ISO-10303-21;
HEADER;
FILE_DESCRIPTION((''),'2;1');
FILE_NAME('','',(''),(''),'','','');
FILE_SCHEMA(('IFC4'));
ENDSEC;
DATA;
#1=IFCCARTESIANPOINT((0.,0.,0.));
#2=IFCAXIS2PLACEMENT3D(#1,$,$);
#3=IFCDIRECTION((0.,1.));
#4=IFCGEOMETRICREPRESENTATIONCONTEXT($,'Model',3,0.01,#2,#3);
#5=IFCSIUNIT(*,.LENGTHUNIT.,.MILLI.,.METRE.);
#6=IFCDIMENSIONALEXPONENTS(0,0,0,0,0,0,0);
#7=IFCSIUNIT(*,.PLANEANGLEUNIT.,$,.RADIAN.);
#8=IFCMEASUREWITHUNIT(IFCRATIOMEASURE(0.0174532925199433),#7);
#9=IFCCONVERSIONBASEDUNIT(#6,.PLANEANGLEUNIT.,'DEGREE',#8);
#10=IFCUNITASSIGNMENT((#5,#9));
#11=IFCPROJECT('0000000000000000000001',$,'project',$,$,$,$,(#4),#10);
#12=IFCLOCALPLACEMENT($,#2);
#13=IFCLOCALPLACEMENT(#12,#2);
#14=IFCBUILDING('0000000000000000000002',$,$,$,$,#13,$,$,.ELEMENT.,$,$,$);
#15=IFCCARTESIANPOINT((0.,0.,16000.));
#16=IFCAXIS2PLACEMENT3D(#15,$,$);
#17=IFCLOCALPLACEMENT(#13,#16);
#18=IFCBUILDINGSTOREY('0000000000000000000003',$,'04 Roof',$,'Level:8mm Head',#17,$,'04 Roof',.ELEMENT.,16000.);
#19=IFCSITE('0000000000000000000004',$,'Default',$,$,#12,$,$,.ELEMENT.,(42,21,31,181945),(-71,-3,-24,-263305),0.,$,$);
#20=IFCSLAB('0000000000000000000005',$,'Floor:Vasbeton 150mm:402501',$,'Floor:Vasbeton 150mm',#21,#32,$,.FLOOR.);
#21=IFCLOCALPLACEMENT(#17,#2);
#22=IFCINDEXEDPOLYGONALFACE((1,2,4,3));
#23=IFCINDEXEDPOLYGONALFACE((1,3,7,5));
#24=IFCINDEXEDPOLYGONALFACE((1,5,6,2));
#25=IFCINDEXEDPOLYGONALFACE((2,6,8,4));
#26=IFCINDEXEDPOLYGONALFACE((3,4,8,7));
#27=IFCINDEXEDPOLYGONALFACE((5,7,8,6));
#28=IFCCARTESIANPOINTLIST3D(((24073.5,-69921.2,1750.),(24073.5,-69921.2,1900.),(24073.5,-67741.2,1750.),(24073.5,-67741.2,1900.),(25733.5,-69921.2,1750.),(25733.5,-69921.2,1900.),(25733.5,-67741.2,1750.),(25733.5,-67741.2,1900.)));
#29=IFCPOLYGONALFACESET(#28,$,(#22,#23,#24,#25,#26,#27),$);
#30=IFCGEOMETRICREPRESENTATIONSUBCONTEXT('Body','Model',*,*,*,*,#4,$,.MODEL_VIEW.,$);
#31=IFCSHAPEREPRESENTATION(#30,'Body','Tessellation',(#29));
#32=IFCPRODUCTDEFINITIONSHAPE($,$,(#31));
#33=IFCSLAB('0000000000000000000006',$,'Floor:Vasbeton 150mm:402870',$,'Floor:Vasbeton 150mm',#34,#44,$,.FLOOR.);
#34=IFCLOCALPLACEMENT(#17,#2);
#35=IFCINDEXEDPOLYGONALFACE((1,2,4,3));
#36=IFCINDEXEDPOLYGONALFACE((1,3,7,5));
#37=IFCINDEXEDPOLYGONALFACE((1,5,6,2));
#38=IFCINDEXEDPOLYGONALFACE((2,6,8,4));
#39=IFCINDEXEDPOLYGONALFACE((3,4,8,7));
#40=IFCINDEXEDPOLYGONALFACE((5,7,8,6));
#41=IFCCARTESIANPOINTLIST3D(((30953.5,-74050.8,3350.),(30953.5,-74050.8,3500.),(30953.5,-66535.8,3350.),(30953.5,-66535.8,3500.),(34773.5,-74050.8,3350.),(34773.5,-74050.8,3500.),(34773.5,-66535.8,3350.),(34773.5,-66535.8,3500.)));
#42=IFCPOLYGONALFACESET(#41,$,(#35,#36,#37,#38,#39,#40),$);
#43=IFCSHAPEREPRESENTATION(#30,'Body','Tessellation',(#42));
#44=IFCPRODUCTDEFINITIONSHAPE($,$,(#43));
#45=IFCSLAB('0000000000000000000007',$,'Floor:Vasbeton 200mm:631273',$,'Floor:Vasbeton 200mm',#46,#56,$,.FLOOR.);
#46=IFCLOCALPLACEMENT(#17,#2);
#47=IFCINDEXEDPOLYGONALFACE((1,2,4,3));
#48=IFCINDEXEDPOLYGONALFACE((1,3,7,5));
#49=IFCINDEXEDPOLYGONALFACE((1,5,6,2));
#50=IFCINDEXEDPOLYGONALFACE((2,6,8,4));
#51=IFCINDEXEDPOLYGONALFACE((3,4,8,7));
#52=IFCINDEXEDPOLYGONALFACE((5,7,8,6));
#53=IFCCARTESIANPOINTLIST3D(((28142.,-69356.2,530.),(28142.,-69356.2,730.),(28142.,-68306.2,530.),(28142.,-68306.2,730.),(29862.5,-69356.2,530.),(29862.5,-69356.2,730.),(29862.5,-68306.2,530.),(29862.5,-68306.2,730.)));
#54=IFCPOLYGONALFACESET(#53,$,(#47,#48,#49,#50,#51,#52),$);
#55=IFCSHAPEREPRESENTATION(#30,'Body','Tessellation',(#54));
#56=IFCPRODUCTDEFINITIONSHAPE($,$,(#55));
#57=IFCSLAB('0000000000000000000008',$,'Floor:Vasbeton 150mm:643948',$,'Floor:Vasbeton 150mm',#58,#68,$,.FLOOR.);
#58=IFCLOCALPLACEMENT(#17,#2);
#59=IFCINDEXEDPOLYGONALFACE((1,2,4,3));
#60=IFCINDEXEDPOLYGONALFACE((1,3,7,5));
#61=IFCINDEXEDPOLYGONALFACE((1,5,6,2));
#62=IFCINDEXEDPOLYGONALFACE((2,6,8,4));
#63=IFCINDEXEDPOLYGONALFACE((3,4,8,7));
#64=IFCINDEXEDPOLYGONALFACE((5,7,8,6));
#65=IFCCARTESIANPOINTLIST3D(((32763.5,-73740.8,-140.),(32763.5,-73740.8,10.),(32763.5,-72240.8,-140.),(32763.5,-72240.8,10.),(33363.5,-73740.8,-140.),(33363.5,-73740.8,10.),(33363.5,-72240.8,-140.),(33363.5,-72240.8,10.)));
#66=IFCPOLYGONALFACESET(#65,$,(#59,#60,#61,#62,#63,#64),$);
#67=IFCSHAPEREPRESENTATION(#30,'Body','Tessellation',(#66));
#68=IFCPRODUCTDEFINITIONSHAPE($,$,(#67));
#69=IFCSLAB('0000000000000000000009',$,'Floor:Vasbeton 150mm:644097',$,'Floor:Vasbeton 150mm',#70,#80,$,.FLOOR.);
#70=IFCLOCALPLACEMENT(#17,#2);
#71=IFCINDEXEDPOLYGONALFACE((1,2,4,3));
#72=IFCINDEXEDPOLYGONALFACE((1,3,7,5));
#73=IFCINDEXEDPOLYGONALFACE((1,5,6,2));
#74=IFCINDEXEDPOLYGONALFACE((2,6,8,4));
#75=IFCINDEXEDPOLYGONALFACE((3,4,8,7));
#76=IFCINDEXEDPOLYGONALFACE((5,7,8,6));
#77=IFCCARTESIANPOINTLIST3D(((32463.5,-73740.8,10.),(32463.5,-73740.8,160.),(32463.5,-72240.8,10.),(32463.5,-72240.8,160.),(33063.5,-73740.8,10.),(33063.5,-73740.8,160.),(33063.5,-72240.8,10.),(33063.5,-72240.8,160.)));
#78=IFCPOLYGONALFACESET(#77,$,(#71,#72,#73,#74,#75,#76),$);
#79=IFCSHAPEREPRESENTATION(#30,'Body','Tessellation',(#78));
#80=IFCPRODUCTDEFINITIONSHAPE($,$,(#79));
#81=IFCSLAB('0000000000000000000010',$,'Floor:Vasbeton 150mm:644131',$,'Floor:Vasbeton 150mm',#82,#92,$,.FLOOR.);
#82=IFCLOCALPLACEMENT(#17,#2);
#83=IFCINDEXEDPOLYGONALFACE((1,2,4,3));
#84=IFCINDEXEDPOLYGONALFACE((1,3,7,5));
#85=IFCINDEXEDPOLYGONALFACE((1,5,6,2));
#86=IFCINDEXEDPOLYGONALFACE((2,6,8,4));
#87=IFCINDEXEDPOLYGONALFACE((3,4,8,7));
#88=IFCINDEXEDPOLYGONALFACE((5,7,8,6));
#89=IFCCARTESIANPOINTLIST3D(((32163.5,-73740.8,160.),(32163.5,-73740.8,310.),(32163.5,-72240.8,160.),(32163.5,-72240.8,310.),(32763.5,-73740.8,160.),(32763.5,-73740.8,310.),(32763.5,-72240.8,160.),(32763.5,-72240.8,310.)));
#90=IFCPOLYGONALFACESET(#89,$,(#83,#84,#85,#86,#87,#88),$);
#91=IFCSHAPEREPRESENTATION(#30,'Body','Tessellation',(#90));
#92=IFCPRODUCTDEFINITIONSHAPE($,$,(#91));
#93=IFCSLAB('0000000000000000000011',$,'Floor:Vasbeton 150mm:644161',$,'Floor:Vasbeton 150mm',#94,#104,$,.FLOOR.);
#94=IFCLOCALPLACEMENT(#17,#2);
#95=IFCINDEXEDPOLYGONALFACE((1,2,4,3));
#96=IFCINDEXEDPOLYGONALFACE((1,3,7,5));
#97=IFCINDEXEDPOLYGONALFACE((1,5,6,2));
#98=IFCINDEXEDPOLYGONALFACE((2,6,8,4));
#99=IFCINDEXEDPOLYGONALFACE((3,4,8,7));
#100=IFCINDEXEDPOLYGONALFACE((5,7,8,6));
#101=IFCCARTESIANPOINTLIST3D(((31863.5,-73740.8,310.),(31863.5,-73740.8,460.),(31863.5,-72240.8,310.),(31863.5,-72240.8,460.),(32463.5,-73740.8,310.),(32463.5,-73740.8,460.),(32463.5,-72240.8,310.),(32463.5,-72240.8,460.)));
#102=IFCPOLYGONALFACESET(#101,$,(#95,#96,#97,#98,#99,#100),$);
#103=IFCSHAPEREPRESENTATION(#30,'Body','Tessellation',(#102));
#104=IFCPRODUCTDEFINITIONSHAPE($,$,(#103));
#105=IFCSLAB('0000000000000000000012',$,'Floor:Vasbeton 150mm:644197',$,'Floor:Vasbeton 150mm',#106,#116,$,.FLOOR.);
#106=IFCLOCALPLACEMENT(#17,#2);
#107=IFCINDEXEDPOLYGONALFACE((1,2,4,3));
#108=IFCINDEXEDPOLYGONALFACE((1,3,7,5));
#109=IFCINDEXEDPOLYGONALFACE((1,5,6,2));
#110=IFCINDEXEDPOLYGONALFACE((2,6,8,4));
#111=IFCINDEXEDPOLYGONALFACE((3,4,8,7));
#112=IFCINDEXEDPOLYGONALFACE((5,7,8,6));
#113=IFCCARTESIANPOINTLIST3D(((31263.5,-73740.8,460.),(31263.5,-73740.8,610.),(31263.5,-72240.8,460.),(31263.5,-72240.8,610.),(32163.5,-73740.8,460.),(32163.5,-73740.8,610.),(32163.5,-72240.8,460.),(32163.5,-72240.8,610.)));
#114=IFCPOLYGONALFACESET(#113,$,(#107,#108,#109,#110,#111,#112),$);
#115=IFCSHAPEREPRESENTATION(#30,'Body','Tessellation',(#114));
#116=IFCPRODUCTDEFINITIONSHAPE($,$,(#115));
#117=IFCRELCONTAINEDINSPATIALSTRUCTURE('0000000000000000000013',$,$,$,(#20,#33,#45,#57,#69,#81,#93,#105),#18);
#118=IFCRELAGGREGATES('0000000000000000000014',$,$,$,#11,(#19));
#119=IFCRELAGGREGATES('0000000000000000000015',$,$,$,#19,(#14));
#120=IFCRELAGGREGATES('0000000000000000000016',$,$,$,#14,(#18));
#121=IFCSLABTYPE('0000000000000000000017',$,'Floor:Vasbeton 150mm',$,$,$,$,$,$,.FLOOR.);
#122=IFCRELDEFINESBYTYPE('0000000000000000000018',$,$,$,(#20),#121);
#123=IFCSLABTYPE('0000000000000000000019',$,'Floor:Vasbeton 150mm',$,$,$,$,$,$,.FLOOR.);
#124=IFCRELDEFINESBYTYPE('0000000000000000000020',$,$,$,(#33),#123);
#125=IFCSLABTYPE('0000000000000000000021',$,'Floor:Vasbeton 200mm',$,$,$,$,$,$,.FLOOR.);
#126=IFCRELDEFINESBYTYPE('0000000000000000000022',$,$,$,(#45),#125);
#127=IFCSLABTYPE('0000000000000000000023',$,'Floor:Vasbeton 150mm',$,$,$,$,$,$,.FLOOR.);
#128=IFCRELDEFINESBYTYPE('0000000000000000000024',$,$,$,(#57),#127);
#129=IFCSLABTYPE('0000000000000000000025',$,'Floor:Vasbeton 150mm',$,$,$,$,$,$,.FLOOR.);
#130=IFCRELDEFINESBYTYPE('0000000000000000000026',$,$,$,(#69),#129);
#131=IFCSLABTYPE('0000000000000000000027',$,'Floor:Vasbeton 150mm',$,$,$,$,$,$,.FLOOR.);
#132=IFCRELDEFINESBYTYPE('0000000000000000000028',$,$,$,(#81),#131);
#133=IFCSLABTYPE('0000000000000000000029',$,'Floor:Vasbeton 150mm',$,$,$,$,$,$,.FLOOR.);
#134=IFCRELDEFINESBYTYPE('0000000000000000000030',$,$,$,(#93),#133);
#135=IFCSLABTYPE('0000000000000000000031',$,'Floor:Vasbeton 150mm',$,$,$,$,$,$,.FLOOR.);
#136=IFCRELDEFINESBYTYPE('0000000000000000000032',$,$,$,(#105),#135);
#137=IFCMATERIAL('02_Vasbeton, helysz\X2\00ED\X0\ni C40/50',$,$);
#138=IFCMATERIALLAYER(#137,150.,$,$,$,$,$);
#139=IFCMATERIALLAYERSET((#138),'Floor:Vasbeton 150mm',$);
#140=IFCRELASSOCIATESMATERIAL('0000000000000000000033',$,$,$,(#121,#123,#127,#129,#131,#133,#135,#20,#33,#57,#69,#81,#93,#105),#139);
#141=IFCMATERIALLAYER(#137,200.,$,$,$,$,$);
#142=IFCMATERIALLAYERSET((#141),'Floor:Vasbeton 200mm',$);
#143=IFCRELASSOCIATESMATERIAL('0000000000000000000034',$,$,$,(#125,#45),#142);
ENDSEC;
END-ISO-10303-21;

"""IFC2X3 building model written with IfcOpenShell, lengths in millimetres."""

from ifc_helpers import new_model, entity, si_unit, converted_unit, direction, frame, frame_2d, origin, origin_2d_with_axis, place, context, subcontext, project, spatial, rectangle, extrude, material, layer, layer_set, layer_usage, type_object, element, save


model = new_model("IFC2X3")

# Units and contexts
model_context = context("Model", 3, precision=0.01, world=origin(), true_north=direction((0.0, 1.0)))
body_context = subcontext(model_context, "Body", "Model", "MODEL_VIEW")
ifc_project = project(units=[si_unit("LENGTHUNIT", "METRE", prefix="MILLI"), converted_unit("PLANEANGLEUNIT", "DEGREE", entity("IfcRatioMeasure", 0.0174532925199433), si_unit("PLANEANGLEUNIT", "RADIAN"), dimensions=[0, 0, 0, 0, 0, 0, 0])], contexts=[model_context])

# Site, building, storey
site_placement = place(None, origin())
site = spatial("IfcSite", under=ifc_project, at=site_placement, Name="Default", CompositionType="ELEMENT", RefLatitude=(42, 21, 31, 181945), RefLongitude=(-71, -3, -24, -263305), RefElevation=0.0)
building_placement = place(site_placement, origin())
building = spatial("IfcBuilding", under=site, at=building_placement, CompositionType="ELEMENT")
storey_placement = place(building_placement, frame((0.0, 0.0, 16000.0)))
storey = spatial("IfcBuildingStorey", under=building, at=storey_placement, Name="04 Roof", ObjectType="Level:8mm Head", LongName="04 Roof", CompositionType="ELEMENT", Elevation=16000.0)

# Shared definitions
ifc_material = material(Name="02_Vasbeton, helyszíni C40/50")
ifc_layer_1 = layer(ifc_material, 200.0)
ifc_layer_set_1 = layer_set([ifc_layer_1], Name="Floor:Vasbeton 200mm")

# Slabs
ifc_layer_2 = layer(ifc_material, 150.0)
ifc_layer_set_2 = layer_set([ifc_layer_2], Name="Floor:Vasbeton 150mm")
ifc_layer_usage_1 = layer_usage(ifc_layer_set_2, "AXIS3", "POSITIVE", 0.0)
slab_type_1 = type_object("IfcSlabType", Name="Floor:Vasbeton 150mm", PredefinedType="FLOOR", material=ifc_layer_set_2)
slab_1_placement = place(storey_placement, origin())
element("IfcSlab", 1, at=slab_1_placement, inside=storey, type_object=slab_type_1, material=ifc_layer_usage_1, Name="Floor:Vasbeton 150mm:402501", ObjectType="Floor:Vasbeton 150mm", PredefinedType="FLOOR", context=body_context, shape_type="SweptSolid", body=[
    extrude(rectangle(XDim=2180.0, YDim=1660.0, at=frame_2d((0.0, 0.0), x_axis=(1.0, 0.0))), frame((24903.5, -68831.2, 1900.0), z_axis=(0.0, 0.0, -1.0), x_axis=(0.0, 1.0, 0.0)), (0.0, 0.0, 1.0), 150.0),
])
ifc_layer_usage_2 = layer_usage(ifc_layer_set_2, "AXIS3", "POSITIVE", 0.0)
slab_type_2 = type_object("IfcSlabType", Name="Floor:Vasbeton 150mm", PredefinedType="FLOOR", material=ifc_layer_set_2)
slab_2_placement = place(storey_placement, origin())
element("IfcSlab", 2, at=slab_2_placement, inside=storey, type_object=slab_type_2, material=ifc_layer_usage_2, Name="Floor:Vasbeton 150mm:402870", ObjectType="Floor:Vasbeton 150mm", PredefinedType="FLOOR", context=body_context, shape_type="SweptSolid", body=[
    extrude(rectangle(XDim=7515.0, YDim=3820.0, at=origin_2d_with_axis()), frame((32863.5, -70293.3, 3500.0), z_axis=(0.0, 0.0, -1.0), x_axis=(0.0, 1.0, 0.0)), (0.0, 0.0, 1.0), 150.0),
])
ifc_layer_usage_3 = layer_usage(ifc_layer_set_1, "AXIS3", "POSITIVE", 0.0)
slab_type_3 = type_object("IfcSlabType", Name="Floor:Vasbeton 200mm", PredefinedType="FLOOR", material=ifc_layer_set_1)
slab_3_placement = place(storey_placement, origin())
element("IfcSlab", 3, at=slab_3_placement, inside=storey, type_object=slab_type_3, material=ifc_layer_usage_3, Name="Floor:Vasbeton 200mm:631273", ObjectType="Floor:Vasbeton 200mm", PredefinedType="FLOOR", context=body_context, shape_type="SweptSolid", body=[
    extrude(rectangle(XDim=1050.0, YDim=1720.4, at=frame_2d((0.0, 0.0), x_axis=(1.0, 0.0))), frame((29002.2, -68831.2, 730.0), z_axis=(0.0, 0.0, -1.0), x_axis=(0.0, 1.0, 0.0)), (0.0, 0.0, 1.0), 200.0),
])
ifc_layer_usage_4 = layer_usage(ifc_layer_set_2, "AXIS3", "POSITIVE", 0.0)
slab_type_4 = type_object("IfcSlabType", Name="Floor:Vasbeton 150mm", PredefinedType="FLOOR", material=ifc_layer_set_2)
slab_4_placement = place(storey_placement, origin())
element("IfcSlab", 4, at=slab_4_placement, inside=storey, type_object=slab_type_4, material=ifc_layer_usage_4, Name="Floor:Vasbeton 150mm:643948", ObjectType="Floor:Vasbeton 150mm", PredefinedType="FLOOR", context=body_context, shape_type="SweptSolid", body=[
    extrude(rectangle(XDim=1500.0, YDim=600.0, at=frame_2d((0.0, 0.0), x_axis=(1.0, 0.0))), frame((33063.5, -72990.8, 10.0), z_axis=(0.0, 0.0, -1.0), x_axis=(0.0, 1.0, 0.0)), (0.0, 0.0, 1.0), 150.0),
])
ifc_layer_usage_5 = layer_usage(ifc_layer_set_2, "AXIS3", "POSITIVE", 0.0)
slab_type_5 = type_object("IfcSlabType", Name="Floor:Vasbeton 150mm", PredefinedType="FLOOR", material=ifc_layer_set_2)
slab_5_placement = place(storey_placement, origin())
element("IfcSlab", 5, at=slab_5_placement, inside=storey, type_object=slab_type_5, material=ifc_layer_usage_5, Name="Floor:Vasbeton 150mm:644097", ObjectType="Floor:Vasbeton 150mm", PredefinedType="FLOOR", context=body_context, shape_type="SweptSolid", body=[
    extrude(rectangle(XDim=1500.0, YDim=600.0, at=frame_2d((0.0, 0.0), x_axis=(1.0, 0.0))), frame((32763.5, -72990.8, 160.0), z_axis=(0.0, 0.0, -1.0), x_axis=(0.0, 1.0, 0.0)), (0.0, 0.0, 1.0), 150.0),
])
ifc_layer_usage_6 = layer_usage(ifc_layer_set_2, "AXIS3", "POSITIVE", 0.0)
slab_type_6 = type_object("IfcSlabType", Name="Floor:Vasbeton 150mm", PredefinedType="FLOOR", material=ifc_layer_set_2)
slab_6_placement = place(storey_placement, origin())
element("IfcSlab", 6, at=slab_6_placement, inside=storey, type_object=slab_type_6, material=ifc_layer_usage_6, Name="Floor:Vasbeton 150mm:644131", ObjectType="Floor:Vasbeton 150mm", PredefinedType="FLOOR", context=body_context, shape_type="SweptSolid", body=[
    extrude(rectangle(XDim=1500.0, YDim=600.0, at=frame_2d((0.0, 0.0), x_axis=(1.0, 0.0))), frame((32463.5, -72990.8, 310.0), z_axis=(0.0, 0.0, -1.0), x_axis=(0.0, 1.0, 0.0)), (0.0, 0.0, 1.0), 150.0),
])
ifc_layer_usage_7 = layer_usage(ifc_layer_set_2, "AXIS3", "POSITIVE", 0.0)
slab_type_7 = type_object("IfcSlabType", Name="Floor:Vasbeton 150mm", PredefinedType="FLOOR", material=ifc_layer_set_2)
slab_7_placement = place(storey_placement, origin())
element("IfcSlab", 7, at=slab_7_placement, inside=storey, type_object=slab_type_7, material=ifc_layer_usage_7, Name="Floor:Vasbeton 150mm:644161", ObjectType="Floor:Vasbeton 150mm", PredefinedType="FLOOR", context=body_context, shape_type="SweptSolid", body=[
    extrude(rectangle(XDim=1500.0, YDim=600.0, at=frame_2d((0.0, 0.0), x_axis=(1.0, 0.0))), frame((32163.5, -72990.8, 460.0), z_axis=(0.0, 0.0, -1.0), x_axis=(0.0, 1.0, 0.0)), (0.0, 0.0, 1.0), 150.0),
])
ifc_layer_usage_8 = layer_usage(ifc_layer_set_2, "AXIS3", "POSITIVE", 0.0)
slab_type_8 = type_object("IfcSlabType", Name="Floor:Vasbeton 150mm", PredefinedType="FLOOR", material=ifc_layer_set_2)
slab_8_placement = place(storey_placement, origin())
element("IfcSlab", 8, at=slab_8_placement, inside=storey, type_object=slab_type_8, material=ifc_layer_usage_8, Name="Floor:Vasbeton 150mm:644197", ObjectType="Floor:Vasbeton 150mm", PredefinedType="FLOOR", context=body_context, shape_type="SweptSolid", body=[
    extrude(rectangle(XDim=1500.0, YDim=900.0, at=frame_2d((0.0, 0.0), x_axis=(1.0, 0.0))), frame((31713.5, -72990.8, 610.0), z_axis=(0.0, 0.0, -1.0), x_axis=(0.0, 1.0, 0.0)), (0.0, 0.0, 1.0), 150.0),
])

save(model, "model.ifc")
